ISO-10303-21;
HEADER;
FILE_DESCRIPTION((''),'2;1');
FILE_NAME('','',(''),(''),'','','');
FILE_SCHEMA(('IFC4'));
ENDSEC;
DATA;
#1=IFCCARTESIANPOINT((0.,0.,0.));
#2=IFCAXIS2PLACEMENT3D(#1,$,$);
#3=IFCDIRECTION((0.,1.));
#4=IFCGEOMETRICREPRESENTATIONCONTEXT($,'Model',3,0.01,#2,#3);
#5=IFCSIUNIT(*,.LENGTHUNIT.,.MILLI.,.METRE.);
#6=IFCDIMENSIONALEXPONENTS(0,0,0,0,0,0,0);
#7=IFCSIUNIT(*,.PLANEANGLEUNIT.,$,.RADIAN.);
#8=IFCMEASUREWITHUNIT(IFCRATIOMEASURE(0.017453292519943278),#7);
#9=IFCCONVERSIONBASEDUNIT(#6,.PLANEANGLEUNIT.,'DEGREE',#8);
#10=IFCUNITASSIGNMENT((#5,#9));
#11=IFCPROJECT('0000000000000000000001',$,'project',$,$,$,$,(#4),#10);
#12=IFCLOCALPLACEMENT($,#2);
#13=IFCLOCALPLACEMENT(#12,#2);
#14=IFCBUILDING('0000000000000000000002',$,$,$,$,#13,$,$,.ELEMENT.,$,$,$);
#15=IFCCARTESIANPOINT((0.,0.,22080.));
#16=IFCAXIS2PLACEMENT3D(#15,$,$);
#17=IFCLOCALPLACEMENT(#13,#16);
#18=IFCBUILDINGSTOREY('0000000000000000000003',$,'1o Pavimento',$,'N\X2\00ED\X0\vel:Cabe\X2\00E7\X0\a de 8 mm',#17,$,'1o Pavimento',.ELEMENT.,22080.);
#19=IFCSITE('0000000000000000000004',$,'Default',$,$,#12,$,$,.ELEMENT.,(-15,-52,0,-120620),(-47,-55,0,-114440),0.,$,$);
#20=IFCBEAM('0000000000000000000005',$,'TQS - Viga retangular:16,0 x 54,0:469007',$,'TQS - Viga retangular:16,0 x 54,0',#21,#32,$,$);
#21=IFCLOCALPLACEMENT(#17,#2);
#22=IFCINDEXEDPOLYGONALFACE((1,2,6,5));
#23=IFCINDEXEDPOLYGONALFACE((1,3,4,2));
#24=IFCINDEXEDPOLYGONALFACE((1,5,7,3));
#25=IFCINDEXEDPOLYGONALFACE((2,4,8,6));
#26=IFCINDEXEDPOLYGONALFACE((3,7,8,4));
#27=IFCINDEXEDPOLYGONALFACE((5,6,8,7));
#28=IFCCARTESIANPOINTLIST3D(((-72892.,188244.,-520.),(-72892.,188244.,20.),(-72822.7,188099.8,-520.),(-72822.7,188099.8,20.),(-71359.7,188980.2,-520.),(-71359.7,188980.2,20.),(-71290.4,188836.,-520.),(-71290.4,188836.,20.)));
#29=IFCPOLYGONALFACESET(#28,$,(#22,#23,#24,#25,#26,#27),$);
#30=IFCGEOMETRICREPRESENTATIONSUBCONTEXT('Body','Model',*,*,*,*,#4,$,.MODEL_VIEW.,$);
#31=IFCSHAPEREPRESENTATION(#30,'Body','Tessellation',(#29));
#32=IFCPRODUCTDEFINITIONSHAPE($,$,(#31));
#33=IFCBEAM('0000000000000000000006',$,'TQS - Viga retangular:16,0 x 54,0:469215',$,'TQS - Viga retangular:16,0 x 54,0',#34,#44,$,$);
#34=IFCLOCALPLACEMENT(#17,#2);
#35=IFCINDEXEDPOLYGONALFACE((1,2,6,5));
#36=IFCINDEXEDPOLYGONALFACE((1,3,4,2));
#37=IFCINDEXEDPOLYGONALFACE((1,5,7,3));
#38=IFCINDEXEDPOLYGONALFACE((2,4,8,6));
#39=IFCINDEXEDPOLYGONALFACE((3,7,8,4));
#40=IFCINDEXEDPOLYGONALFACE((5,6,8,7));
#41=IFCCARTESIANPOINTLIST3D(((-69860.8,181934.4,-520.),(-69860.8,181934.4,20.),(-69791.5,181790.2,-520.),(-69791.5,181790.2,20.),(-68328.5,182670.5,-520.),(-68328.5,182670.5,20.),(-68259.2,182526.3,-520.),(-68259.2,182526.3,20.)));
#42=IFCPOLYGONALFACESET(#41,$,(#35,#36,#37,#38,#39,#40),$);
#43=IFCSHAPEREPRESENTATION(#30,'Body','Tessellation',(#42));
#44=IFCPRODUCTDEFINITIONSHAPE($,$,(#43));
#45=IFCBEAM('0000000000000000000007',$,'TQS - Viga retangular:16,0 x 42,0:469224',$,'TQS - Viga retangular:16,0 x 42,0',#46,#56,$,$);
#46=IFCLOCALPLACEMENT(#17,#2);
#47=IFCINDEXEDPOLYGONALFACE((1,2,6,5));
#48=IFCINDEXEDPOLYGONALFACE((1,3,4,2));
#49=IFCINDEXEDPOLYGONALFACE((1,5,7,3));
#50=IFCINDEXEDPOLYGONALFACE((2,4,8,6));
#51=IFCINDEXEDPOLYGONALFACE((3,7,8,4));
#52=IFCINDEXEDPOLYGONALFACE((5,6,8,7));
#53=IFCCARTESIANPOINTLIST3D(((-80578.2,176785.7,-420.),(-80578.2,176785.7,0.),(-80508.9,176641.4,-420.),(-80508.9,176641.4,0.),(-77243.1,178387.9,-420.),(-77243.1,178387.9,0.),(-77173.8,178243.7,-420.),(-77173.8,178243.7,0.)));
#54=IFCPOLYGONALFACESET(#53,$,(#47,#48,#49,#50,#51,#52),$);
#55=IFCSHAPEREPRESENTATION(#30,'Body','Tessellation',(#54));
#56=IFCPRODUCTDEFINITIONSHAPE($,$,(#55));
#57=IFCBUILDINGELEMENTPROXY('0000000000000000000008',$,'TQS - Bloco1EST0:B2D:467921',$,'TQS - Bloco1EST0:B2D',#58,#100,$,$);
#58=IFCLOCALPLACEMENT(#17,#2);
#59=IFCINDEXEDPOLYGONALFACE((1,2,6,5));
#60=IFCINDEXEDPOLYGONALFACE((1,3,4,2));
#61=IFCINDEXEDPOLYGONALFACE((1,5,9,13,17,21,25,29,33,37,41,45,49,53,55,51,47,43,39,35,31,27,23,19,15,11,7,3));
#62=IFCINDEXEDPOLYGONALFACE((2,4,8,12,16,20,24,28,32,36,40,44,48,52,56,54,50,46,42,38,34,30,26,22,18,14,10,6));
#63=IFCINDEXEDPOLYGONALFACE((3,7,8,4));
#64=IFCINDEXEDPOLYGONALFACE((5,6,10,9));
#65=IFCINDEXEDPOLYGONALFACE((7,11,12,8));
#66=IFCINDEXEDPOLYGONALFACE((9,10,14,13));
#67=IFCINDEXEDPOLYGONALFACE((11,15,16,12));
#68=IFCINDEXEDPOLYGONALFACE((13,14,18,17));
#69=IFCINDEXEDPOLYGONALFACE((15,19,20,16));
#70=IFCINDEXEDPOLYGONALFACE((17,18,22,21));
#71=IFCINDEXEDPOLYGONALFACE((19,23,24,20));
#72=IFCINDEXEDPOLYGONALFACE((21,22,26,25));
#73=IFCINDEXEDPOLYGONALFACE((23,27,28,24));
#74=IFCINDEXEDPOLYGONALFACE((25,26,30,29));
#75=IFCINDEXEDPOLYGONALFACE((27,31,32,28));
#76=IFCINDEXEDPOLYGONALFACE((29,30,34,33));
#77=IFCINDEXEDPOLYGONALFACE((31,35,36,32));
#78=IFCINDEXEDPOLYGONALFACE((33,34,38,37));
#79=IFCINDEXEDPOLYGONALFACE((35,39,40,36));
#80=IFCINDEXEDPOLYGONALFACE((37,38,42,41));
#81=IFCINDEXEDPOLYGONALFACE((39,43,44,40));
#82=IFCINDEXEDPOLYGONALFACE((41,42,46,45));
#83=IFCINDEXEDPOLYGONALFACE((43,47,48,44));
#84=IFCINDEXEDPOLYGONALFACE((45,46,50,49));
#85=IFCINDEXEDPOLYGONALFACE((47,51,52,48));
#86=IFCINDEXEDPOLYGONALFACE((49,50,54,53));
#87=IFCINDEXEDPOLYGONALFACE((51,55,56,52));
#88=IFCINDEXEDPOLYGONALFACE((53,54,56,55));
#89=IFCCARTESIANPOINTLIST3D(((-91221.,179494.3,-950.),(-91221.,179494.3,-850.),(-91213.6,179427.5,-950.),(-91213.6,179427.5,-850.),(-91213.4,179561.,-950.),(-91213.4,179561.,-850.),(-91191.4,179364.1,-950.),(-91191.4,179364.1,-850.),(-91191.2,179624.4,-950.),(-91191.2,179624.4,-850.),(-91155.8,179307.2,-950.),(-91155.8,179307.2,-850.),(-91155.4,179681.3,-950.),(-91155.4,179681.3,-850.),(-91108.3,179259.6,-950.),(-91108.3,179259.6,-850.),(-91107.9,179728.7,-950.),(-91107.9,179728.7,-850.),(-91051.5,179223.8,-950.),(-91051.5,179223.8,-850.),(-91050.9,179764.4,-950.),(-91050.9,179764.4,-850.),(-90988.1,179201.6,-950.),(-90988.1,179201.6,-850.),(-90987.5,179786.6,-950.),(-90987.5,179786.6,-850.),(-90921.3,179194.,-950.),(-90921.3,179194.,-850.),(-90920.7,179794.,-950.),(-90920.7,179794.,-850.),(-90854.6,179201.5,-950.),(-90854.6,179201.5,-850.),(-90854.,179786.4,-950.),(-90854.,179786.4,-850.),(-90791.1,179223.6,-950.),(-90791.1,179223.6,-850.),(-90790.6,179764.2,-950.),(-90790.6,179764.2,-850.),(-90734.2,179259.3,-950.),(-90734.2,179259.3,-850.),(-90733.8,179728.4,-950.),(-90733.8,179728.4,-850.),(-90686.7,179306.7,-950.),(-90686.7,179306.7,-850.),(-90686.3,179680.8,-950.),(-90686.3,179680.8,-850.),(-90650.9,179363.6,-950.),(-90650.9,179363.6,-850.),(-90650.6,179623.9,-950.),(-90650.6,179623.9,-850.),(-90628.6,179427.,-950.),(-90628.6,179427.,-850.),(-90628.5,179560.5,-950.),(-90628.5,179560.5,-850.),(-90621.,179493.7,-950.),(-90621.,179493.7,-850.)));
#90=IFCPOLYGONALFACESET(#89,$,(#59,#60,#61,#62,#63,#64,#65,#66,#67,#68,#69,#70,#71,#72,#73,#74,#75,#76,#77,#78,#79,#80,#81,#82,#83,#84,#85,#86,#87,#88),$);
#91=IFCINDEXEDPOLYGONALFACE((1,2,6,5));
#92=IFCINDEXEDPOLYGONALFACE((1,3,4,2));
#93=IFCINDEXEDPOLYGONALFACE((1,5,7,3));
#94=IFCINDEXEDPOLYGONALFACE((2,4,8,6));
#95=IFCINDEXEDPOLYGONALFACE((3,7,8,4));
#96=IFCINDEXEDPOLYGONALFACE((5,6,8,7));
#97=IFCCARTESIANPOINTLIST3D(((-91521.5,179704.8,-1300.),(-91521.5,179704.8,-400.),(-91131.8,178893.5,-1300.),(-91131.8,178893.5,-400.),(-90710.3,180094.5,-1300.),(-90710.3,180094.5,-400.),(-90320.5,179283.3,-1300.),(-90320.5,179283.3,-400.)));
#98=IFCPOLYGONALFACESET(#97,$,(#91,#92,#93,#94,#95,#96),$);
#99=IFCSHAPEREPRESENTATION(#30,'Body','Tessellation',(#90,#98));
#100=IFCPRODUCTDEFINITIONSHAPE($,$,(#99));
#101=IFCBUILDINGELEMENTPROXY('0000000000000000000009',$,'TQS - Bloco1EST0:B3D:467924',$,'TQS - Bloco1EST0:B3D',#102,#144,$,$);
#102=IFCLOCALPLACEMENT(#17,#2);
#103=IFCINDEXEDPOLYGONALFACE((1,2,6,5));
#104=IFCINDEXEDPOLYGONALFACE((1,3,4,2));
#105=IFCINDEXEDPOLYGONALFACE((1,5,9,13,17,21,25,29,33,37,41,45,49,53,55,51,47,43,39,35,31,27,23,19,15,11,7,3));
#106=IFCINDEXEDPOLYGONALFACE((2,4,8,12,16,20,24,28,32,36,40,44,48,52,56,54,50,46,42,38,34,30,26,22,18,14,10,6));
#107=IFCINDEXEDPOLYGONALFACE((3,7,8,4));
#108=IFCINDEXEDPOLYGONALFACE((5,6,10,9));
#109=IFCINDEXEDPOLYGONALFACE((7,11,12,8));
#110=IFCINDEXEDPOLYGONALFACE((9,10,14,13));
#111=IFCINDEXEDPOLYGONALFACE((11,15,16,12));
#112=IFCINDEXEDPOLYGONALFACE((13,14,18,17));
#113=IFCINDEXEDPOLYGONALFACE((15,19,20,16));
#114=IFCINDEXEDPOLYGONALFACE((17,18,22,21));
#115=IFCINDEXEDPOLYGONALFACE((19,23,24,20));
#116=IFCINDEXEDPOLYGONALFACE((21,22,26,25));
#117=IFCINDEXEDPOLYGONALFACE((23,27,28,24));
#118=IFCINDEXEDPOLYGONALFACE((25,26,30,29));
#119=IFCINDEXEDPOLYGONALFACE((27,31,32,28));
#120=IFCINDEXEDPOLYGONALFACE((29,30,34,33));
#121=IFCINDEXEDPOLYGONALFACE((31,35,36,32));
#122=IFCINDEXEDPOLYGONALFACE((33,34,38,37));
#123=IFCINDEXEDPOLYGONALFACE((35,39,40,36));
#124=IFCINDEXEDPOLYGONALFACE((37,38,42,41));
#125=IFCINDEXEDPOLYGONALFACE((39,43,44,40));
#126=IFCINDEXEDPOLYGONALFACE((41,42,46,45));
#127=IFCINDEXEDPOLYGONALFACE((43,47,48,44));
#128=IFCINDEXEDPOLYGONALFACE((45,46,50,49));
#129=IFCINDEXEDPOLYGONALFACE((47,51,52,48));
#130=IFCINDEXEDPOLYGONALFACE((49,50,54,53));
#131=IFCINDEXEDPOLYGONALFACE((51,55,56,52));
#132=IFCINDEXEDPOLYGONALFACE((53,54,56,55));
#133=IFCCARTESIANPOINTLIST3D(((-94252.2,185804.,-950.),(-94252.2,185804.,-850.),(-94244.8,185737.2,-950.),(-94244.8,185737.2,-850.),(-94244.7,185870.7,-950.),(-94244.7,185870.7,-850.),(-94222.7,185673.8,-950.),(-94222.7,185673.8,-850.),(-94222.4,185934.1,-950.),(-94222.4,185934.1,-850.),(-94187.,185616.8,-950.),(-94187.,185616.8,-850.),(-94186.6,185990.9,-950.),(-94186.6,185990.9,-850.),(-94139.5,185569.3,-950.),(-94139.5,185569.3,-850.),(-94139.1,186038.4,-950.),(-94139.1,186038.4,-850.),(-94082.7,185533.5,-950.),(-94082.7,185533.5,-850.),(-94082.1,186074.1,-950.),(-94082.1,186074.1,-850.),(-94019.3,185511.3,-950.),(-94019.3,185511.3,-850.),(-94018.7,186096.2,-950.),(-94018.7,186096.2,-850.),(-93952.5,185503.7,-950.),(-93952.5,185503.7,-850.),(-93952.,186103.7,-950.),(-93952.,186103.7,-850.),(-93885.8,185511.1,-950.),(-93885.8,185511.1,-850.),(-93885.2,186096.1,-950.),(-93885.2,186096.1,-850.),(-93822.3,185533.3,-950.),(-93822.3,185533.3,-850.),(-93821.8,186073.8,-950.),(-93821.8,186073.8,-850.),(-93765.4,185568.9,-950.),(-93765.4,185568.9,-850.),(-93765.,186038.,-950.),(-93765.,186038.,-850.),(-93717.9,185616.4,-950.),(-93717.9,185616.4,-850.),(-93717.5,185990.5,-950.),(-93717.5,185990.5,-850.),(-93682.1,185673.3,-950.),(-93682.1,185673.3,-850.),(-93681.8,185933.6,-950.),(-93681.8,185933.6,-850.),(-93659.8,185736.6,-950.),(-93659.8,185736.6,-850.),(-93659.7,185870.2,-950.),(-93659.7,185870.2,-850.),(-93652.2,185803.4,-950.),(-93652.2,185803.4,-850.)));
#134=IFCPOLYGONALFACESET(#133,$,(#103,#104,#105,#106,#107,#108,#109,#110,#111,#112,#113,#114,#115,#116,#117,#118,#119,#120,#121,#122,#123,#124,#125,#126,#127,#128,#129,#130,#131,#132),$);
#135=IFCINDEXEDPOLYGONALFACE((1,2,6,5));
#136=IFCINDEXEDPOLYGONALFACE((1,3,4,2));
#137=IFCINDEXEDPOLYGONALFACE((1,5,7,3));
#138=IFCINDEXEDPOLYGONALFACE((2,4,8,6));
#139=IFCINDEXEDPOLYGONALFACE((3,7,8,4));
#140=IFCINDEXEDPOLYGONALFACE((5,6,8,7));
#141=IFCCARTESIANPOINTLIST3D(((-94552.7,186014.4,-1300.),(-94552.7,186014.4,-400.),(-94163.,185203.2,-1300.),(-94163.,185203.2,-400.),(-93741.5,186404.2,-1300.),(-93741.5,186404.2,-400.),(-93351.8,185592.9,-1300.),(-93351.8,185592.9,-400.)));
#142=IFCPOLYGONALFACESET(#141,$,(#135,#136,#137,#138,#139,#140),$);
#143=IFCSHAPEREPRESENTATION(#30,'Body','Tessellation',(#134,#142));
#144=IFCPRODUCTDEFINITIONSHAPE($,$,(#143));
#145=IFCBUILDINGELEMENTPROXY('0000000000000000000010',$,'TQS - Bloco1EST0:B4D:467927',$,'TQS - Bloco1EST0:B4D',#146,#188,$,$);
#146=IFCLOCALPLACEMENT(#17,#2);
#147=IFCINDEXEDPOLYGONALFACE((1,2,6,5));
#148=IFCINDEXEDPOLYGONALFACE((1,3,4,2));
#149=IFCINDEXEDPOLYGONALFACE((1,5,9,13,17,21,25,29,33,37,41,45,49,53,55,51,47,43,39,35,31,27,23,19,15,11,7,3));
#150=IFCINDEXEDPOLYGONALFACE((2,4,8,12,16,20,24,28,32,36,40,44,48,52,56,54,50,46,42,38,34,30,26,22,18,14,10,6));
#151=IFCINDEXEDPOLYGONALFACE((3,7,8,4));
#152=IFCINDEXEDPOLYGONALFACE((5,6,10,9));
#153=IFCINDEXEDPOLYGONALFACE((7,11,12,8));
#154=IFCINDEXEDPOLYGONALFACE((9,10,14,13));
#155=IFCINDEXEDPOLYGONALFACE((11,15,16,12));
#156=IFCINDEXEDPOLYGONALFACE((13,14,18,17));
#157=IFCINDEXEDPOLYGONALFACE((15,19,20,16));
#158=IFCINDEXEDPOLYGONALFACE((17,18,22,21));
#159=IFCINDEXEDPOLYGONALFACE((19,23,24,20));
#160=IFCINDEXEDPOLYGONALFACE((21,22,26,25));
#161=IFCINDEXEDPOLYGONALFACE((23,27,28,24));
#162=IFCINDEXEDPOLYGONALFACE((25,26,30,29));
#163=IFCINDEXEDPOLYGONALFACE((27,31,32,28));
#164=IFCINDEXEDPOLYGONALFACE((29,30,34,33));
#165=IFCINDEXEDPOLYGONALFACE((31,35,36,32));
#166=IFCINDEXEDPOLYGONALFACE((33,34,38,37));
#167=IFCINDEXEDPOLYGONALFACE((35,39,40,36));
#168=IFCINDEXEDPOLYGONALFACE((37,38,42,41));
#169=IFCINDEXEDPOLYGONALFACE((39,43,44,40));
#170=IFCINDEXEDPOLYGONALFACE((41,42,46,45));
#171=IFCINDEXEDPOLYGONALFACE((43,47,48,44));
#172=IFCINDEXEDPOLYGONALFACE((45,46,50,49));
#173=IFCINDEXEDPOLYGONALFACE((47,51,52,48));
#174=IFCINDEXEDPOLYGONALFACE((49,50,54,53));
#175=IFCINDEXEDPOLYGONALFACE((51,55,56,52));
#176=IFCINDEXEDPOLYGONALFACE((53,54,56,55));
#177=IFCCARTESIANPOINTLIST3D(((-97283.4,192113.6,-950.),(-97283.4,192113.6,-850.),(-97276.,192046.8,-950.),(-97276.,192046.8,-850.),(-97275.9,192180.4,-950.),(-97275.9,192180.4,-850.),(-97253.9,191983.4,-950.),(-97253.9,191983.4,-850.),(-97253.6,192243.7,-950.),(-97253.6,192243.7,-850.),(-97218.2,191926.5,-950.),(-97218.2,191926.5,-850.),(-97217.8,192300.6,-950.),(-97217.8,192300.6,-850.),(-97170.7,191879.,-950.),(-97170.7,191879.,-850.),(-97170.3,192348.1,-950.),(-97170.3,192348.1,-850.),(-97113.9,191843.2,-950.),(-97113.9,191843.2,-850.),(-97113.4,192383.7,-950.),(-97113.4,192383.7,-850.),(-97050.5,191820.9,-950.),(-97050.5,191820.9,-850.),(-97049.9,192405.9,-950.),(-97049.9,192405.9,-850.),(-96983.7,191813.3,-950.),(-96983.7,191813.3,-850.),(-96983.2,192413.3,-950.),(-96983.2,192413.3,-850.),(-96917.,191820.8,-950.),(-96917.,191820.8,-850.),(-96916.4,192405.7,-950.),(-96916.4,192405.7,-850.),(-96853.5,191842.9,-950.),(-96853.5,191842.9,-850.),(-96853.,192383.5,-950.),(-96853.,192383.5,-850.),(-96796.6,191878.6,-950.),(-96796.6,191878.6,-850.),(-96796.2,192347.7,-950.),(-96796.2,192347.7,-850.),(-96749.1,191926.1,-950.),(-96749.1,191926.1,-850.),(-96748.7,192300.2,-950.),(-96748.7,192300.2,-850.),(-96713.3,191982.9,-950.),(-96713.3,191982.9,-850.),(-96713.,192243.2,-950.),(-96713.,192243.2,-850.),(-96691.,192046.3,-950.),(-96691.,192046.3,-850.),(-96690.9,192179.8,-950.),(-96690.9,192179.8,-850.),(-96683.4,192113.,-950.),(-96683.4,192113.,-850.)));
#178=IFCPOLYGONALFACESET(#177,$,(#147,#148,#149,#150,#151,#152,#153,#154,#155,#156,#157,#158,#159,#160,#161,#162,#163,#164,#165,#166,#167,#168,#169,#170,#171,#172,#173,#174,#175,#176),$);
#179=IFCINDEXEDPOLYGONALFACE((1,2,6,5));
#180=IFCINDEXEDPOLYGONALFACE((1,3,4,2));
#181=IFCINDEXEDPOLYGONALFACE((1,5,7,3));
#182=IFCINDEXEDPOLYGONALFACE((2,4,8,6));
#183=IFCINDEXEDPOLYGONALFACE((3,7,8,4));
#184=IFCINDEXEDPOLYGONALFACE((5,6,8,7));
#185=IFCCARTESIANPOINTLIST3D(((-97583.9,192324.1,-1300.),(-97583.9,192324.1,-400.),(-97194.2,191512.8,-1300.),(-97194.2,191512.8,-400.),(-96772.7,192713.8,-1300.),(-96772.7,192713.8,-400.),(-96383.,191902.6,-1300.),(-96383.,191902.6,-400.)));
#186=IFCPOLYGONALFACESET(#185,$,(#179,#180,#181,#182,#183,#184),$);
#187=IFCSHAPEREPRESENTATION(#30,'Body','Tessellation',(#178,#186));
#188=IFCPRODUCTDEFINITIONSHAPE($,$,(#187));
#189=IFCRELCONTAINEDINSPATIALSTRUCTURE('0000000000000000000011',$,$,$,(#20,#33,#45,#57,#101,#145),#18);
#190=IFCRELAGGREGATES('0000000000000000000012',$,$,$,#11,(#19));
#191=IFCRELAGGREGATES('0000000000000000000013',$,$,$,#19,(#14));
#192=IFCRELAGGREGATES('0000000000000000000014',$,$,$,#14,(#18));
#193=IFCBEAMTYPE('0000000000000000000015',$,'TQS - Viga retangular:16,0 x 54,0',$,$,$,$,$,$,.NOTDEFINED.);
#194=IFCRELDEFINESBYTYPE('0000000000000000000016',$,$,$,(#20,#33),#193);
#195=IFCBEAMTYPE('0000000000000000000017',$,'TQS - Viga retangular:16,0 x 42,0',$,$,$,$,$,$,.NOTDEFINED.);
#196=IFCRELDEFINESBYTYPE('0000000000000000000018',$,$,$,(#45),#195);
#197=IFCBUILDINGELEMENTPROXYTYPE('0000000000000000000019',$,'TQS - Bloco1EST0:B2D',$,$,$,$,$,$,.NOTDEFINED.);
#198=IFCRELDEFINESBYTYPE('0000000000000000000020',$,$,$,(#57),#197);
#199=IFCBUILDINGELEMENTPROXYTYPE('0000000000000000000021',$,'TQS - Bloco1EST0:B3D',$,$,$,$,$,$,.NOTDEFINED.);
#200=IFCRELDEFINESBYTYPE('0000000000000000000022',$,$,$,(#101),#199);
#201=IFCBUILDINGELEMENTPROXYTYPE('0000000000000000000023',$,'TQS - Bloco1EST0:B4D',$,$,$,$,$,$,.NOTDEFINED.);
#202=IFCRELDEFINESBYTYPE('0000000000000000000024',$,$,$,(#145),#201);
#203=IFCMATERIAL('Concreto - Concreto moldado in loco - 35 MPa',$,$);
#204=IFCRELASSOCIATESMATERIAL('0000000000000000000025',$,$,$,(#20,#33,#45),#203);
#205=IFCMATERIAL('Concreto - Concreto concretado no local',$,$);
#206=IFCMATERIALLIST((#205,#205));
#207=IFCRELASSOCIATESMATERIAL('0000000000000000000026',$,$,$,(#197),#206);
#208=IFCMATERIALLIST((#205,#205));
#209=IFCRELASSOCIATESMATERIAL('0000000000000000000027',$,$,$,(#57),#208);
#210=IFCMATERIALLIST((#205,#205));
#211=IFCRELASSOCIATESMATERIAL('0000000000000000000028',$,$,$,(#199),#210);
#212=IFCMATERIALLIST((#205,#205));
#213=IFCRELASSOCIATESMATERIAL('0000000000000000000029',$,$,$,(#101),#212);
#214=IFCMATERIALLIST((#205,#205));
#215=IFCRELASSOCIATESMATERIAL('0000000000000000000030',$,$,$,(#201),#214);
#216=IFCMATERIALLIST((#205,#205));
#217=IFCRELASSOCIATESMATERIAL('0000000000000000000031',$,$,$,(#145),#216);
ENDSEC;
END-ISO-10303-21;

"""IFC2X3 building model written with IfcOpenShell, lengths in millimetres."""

from ifc_helpers import new_model, entity, si_unit, converted_unit, direction, frame, frame_2d, origin, origin_2d_with_axis, place, context, subcontext, project, spatial, rectangle, circle, extrude, source, transform, mapped, material, material_list, type_object, type_shapes, element, save


model = new_model("IFC2X3")

# Units and contexts
model_context = context("Model", 3, precision=0.01, world=origin(), true_north=direction((0.0, 1.0)))
body_context = subcontext(model_context, "Body", "Model", "MODEL_VIEW")
ifc_project = project(units=[si_unit("LENGTHUNIT", "METRE", prefix="MILLI"), converted_unit("PLANEANGLEUNIT", "DEGREE", entity("IfcRatioMeasure", 0.017453292519943278), si_unit("PLANEANGLEUNIT", "RADIAN"), dimensions=[0, 0, 0, 0, 0, 0, 0])], contexts=[model_context])

# Site, building, storey
site_placement = place(None, origin())
site = spatial("IfcSite", under=ifc_project, at=site_placement, Name="Default", CompositionType="ELEMENT", RefLatitude=(-15, -52, 0, -120620), RefLongitude=(-47, -55, 0, -114440), RefElevation=0.0)
building_placement = place(site_placement, origin())
building = spatial("IfcBuilding", under=site, at=building_placement, CompositionType="ELEMENT")
storey_placement = place(building_placement, frame((0.0, 0.0, 22080.0)))
storey = spatial("IfcBuildingStorey", under=building, at=storey_placement, Name="1o Pavimento", ObjectType="Nível:Cabeça de 8 mm", LongName="1o Pavimento", CompositionType="ELEMENT", Elevation=22080.0)

# Beams
ifc_material_1 = material(Name="Concreto - Concreto moldado in loco - 35 MPa")
beam_type_1 = type_object("IfcBeamType", Name="TQS - Viga retangular:16,0 x 54,0", PredefinedType="NOTDEFINED")
beam_1_placement = place(storey_placement, frame((-71325.0, 188908.1, 20.0), z_axis=(0.0, 0.0, 1.0), x_axis=(-0.90138, -0.43303, 0.0)))
element("IfcBeam", 1, at=beam_1_placement, inside=storey, type_object=beam_type_1, material=ifc_material_1, Name="TQS - Viga retangular:16,0 x 54,0:469007", ObjectType="TQS - Viga retangular:16,0 x 54,0", context=body_context, shape_type="SweptSolid", body=[
    extrude(rectangle(XDim=540.0, YDim=160.0, at=frame_2d((0.0, 0.0), x_axis=(1.0, 0.0))), frame((0.0, 0.0, -270.0), z_axis=(1.0, 0.0, 0.0), x_axis=(0.0, 0.0, -1.0)), (0.0, 0.0, 1.0), 1700.0),
])
beam_2_placement = place(storey_placement, frame((-68293.8, 182598.4, 20.0), z_axis=(0.0, 0.0, 1.0), x_axis=(-0.90138, -0.43303, 0.0)))
element("IfcBeam", 2, at=beam_2_placement, inside=storey, type_object=beam_type_1, material=ifc_material_1, Name="TQS - Viga retangular:16,0 x 54,0:469215", ObjectType="TQS - Viga retangular:16,0 x 54,0", context=body_context, shape_type="SweptSolid", body=[
    extrude(rectangle(XDim=540.0, YDim=160.0, at=frame_2d((0.0, 0.0), x_axis=(1.0, 0.0))), frame((0.0, 0.0, -270.0), z_axis=(1.0, 0.0, 0.0), x_axis=(0.0, 0.0, -1.0)), (0.0, 0.0, 1.0), 1700.0),
])
beam_type_2 = type_object("IfcBeamType", Name="TQS - Viga retangular:16,0 x 42,0", PredefinedType="NOTDEFINED")
beam_3_placement = place(storey_placement, frame((-77136.4, 178350.4, 0.0), z_axis=(0.0, 0.0, 1.0), x_axis=(-0.90138, -0.43303, 0.0)))
element("IfcBeam", 3, at=beam_3_placement, inside=storey, type_object=beam_type_2, material=ifc_material_1, Name="TQS - Viga retangular:16,0 x 42,0:469224", ObjectType="TQS - Viga retangular:16,0 x 42,0", context=body_context, shape_type="SweptSolid", body=[
    extrude(rectangle(XDim=420.0, YDim=160.0, at=frame_2d((0.0, 0.0), x_axis=(1.0, 0.0))), frame((80.0, 0.0, -210.0), z_axis=(1.0, 0.0, 0.0), x_axis=(0.0, 0.0, -1.0)), (0.0, 0.0, 1.0), 3700.0),
])

# Building element proxies
ifc_material_2 = material(Name="Concreto - Concreto concretado no local")
ifc_material_list_1 = material_list([ifc_material_2, ifc_material_2])
ifc_material_list_2 = material_list([ifc_material_2, ifc_material_2])
building_element_proxy_type_1 = type_object("IfcBuildingElementProxyType", Name="TQS - Bloco1EST0:B2D", PredefinedType="NOTDEFINED", material=ifc_material_list_2)
shared_shape_1 = source(origin(), body_context, "Body", "SweptSolid", [
    extrude(circle(Radius=300.0, at=frame_2d((0.0, 0.0), x_axis=(1.0, 0.0))), frame((0.0, 0.0, -550.0)), (0.0, 0.0, 1.0), 100.0),
    extrude(rectangle(XDim=900.0, YDim=900.0, at=origin_2d_with_axis()), frame((0.0, 0.0, -900.0), z_axis=(0.0, 0.0, 1.0), x_axis=(-1.0, 0.0, 0.0)), (0.0, 0.0, 1.0), 900.0),
])
type_shapes(building_element_proxy_type_1, [shared_shape_1])
proxy_1_placement = place(storey_placement, frame((-90921.0, 179494.0, -400.0), z_axis=(0.0, 0.0, 1.0), x_axis=(-0.43303, 0.90138, 0.0)))
element("IfcBuildingElementProxy", 4, at=proxy_1_placement, inside=storey, type_object=building_element_proxy_type_1, material=ifc_material_list_1, Name="TQS - Bloco1EST0:B2D:467921", ObjectType="TQS - Bloco1EST0:B2D", context=body_context, shape_type="MappedRepresentation", body=[
    mapped(shared_shape_1, transform((0.0, 0.0, 0.0), scale=1.0)),
])
ifc_material_list_3 = material_list([ifc_material_2, ifc_material_2])
ifc_material_list_4 = material_list([ifc_material_2, ifc_material_2])
building_element_proxy_type_2 = type_object("IfcBuildingElementProxyType", Name="TQS - Bloco1EST0:B3D", PredefinedType="NOTDEFINED", material=ifc_material_list_4)
shared_shape_2 = source(origin(), body_context, "Body", "SweptSolid", [
    extrude(circle(Radius=300.0, at=frame_2d((0.0, 0.0), x_axis=(1.0, 0.0))), frame((0.0, 0.0, -550.0)), (0.0, 0.0, 1.0), 100.0),
    extrude(rectangle(XDim=900.0, YDim=900.0, at=origin_2d_with_axis()), frame((0.0, 0.0, -900.0), z_axis=(0.0, 0.0, 1.0), x_axis=(-1.0, 0.0, 0.0)), (0.0, 0.0, 1.0), 900.0),
])
type_shapes(building_element_proxy_type_2, [shared_shape_2])
proxy_2_placement = place(storey_placement, frame((-93952.2, 185803.7, -400.0), z_axis=(0.0, 0.0, 1.0), x_axis=(-0.43303, 0.90138, 0.0)))
element("IfcBuildingElementProxy", 5, at=proxy_2_placement, inside=storey, type_object=building_element_proxy_type_2, material=ifc_material_list_3, Name="TQS - Bloco1EST0:B3D:467924", ObjectType="TQS - Bloco1EST0:B3D", context=body_context, shape_type="MappedRepresentation", body=[
    mapped(shared_shape_2, transform((0.0, 0.0, 0.0), scale=1.0)),
])
ifc_material_list_5 = material_list([ifc_material_2, ifc_material_2])
ifc_material_list_6 = material_list([ifc_material_2, ifc_material_2])
building_element_proxy_type_3 = type_object("IfcBuildingElementProxyType", Name="TQS - Bloco1EST0:B4D", PredefinedType="NOTDEFINED", material=ifc_material_list_6)
shared_shape_3 = source(origin(), body_context, "Body", "SweptSolid", [
    extrude(circle(Radius=300.0, at=frame_2d((0.0, 0.0), x_axis=(1.0, 0.0))), frame((0.0, 0.0, -550.0)), (0.0, 0.0, 1.0), 100.0),
    extrude(rectangle(XDim=900.0, YDim=900.0, at=origin_2d_with_axis()), frame((0.0, 0.0, -900.0), z_axis=(0.0, 0.0, 1.0), x_axis=(-1.0, 0.0, 0.0)), (0.0, 0.0, 1.0), 900.0),
])
type_shapes(building_element_proxy_type_3, [shared_shape_3])
proxy_3_placement = place(storey_placement, frame((-96983.4, 192113.3, -400.0), z_axis=(0.0, 0.0, 1.0), x_axis=(-0.43303, 0.90138, 0.0)))
element("IfcBuildingElementProxy", 6, at=proxy_3_placement, inside=storey, type_object=building_element_proxy_type_3, material=ifc_material_list_5, Name="TQS - Bloco1EST0:B4D:467927", ObjectType="TQS - Bloco1EST0:B4D", context=body_context, shape_type="MappedRepresentation", body=[
    mapped(shared_shape_3, transform((0.0, 0.0, 0.0), scale=1.0)),
])

save(model, "model.ifc")
